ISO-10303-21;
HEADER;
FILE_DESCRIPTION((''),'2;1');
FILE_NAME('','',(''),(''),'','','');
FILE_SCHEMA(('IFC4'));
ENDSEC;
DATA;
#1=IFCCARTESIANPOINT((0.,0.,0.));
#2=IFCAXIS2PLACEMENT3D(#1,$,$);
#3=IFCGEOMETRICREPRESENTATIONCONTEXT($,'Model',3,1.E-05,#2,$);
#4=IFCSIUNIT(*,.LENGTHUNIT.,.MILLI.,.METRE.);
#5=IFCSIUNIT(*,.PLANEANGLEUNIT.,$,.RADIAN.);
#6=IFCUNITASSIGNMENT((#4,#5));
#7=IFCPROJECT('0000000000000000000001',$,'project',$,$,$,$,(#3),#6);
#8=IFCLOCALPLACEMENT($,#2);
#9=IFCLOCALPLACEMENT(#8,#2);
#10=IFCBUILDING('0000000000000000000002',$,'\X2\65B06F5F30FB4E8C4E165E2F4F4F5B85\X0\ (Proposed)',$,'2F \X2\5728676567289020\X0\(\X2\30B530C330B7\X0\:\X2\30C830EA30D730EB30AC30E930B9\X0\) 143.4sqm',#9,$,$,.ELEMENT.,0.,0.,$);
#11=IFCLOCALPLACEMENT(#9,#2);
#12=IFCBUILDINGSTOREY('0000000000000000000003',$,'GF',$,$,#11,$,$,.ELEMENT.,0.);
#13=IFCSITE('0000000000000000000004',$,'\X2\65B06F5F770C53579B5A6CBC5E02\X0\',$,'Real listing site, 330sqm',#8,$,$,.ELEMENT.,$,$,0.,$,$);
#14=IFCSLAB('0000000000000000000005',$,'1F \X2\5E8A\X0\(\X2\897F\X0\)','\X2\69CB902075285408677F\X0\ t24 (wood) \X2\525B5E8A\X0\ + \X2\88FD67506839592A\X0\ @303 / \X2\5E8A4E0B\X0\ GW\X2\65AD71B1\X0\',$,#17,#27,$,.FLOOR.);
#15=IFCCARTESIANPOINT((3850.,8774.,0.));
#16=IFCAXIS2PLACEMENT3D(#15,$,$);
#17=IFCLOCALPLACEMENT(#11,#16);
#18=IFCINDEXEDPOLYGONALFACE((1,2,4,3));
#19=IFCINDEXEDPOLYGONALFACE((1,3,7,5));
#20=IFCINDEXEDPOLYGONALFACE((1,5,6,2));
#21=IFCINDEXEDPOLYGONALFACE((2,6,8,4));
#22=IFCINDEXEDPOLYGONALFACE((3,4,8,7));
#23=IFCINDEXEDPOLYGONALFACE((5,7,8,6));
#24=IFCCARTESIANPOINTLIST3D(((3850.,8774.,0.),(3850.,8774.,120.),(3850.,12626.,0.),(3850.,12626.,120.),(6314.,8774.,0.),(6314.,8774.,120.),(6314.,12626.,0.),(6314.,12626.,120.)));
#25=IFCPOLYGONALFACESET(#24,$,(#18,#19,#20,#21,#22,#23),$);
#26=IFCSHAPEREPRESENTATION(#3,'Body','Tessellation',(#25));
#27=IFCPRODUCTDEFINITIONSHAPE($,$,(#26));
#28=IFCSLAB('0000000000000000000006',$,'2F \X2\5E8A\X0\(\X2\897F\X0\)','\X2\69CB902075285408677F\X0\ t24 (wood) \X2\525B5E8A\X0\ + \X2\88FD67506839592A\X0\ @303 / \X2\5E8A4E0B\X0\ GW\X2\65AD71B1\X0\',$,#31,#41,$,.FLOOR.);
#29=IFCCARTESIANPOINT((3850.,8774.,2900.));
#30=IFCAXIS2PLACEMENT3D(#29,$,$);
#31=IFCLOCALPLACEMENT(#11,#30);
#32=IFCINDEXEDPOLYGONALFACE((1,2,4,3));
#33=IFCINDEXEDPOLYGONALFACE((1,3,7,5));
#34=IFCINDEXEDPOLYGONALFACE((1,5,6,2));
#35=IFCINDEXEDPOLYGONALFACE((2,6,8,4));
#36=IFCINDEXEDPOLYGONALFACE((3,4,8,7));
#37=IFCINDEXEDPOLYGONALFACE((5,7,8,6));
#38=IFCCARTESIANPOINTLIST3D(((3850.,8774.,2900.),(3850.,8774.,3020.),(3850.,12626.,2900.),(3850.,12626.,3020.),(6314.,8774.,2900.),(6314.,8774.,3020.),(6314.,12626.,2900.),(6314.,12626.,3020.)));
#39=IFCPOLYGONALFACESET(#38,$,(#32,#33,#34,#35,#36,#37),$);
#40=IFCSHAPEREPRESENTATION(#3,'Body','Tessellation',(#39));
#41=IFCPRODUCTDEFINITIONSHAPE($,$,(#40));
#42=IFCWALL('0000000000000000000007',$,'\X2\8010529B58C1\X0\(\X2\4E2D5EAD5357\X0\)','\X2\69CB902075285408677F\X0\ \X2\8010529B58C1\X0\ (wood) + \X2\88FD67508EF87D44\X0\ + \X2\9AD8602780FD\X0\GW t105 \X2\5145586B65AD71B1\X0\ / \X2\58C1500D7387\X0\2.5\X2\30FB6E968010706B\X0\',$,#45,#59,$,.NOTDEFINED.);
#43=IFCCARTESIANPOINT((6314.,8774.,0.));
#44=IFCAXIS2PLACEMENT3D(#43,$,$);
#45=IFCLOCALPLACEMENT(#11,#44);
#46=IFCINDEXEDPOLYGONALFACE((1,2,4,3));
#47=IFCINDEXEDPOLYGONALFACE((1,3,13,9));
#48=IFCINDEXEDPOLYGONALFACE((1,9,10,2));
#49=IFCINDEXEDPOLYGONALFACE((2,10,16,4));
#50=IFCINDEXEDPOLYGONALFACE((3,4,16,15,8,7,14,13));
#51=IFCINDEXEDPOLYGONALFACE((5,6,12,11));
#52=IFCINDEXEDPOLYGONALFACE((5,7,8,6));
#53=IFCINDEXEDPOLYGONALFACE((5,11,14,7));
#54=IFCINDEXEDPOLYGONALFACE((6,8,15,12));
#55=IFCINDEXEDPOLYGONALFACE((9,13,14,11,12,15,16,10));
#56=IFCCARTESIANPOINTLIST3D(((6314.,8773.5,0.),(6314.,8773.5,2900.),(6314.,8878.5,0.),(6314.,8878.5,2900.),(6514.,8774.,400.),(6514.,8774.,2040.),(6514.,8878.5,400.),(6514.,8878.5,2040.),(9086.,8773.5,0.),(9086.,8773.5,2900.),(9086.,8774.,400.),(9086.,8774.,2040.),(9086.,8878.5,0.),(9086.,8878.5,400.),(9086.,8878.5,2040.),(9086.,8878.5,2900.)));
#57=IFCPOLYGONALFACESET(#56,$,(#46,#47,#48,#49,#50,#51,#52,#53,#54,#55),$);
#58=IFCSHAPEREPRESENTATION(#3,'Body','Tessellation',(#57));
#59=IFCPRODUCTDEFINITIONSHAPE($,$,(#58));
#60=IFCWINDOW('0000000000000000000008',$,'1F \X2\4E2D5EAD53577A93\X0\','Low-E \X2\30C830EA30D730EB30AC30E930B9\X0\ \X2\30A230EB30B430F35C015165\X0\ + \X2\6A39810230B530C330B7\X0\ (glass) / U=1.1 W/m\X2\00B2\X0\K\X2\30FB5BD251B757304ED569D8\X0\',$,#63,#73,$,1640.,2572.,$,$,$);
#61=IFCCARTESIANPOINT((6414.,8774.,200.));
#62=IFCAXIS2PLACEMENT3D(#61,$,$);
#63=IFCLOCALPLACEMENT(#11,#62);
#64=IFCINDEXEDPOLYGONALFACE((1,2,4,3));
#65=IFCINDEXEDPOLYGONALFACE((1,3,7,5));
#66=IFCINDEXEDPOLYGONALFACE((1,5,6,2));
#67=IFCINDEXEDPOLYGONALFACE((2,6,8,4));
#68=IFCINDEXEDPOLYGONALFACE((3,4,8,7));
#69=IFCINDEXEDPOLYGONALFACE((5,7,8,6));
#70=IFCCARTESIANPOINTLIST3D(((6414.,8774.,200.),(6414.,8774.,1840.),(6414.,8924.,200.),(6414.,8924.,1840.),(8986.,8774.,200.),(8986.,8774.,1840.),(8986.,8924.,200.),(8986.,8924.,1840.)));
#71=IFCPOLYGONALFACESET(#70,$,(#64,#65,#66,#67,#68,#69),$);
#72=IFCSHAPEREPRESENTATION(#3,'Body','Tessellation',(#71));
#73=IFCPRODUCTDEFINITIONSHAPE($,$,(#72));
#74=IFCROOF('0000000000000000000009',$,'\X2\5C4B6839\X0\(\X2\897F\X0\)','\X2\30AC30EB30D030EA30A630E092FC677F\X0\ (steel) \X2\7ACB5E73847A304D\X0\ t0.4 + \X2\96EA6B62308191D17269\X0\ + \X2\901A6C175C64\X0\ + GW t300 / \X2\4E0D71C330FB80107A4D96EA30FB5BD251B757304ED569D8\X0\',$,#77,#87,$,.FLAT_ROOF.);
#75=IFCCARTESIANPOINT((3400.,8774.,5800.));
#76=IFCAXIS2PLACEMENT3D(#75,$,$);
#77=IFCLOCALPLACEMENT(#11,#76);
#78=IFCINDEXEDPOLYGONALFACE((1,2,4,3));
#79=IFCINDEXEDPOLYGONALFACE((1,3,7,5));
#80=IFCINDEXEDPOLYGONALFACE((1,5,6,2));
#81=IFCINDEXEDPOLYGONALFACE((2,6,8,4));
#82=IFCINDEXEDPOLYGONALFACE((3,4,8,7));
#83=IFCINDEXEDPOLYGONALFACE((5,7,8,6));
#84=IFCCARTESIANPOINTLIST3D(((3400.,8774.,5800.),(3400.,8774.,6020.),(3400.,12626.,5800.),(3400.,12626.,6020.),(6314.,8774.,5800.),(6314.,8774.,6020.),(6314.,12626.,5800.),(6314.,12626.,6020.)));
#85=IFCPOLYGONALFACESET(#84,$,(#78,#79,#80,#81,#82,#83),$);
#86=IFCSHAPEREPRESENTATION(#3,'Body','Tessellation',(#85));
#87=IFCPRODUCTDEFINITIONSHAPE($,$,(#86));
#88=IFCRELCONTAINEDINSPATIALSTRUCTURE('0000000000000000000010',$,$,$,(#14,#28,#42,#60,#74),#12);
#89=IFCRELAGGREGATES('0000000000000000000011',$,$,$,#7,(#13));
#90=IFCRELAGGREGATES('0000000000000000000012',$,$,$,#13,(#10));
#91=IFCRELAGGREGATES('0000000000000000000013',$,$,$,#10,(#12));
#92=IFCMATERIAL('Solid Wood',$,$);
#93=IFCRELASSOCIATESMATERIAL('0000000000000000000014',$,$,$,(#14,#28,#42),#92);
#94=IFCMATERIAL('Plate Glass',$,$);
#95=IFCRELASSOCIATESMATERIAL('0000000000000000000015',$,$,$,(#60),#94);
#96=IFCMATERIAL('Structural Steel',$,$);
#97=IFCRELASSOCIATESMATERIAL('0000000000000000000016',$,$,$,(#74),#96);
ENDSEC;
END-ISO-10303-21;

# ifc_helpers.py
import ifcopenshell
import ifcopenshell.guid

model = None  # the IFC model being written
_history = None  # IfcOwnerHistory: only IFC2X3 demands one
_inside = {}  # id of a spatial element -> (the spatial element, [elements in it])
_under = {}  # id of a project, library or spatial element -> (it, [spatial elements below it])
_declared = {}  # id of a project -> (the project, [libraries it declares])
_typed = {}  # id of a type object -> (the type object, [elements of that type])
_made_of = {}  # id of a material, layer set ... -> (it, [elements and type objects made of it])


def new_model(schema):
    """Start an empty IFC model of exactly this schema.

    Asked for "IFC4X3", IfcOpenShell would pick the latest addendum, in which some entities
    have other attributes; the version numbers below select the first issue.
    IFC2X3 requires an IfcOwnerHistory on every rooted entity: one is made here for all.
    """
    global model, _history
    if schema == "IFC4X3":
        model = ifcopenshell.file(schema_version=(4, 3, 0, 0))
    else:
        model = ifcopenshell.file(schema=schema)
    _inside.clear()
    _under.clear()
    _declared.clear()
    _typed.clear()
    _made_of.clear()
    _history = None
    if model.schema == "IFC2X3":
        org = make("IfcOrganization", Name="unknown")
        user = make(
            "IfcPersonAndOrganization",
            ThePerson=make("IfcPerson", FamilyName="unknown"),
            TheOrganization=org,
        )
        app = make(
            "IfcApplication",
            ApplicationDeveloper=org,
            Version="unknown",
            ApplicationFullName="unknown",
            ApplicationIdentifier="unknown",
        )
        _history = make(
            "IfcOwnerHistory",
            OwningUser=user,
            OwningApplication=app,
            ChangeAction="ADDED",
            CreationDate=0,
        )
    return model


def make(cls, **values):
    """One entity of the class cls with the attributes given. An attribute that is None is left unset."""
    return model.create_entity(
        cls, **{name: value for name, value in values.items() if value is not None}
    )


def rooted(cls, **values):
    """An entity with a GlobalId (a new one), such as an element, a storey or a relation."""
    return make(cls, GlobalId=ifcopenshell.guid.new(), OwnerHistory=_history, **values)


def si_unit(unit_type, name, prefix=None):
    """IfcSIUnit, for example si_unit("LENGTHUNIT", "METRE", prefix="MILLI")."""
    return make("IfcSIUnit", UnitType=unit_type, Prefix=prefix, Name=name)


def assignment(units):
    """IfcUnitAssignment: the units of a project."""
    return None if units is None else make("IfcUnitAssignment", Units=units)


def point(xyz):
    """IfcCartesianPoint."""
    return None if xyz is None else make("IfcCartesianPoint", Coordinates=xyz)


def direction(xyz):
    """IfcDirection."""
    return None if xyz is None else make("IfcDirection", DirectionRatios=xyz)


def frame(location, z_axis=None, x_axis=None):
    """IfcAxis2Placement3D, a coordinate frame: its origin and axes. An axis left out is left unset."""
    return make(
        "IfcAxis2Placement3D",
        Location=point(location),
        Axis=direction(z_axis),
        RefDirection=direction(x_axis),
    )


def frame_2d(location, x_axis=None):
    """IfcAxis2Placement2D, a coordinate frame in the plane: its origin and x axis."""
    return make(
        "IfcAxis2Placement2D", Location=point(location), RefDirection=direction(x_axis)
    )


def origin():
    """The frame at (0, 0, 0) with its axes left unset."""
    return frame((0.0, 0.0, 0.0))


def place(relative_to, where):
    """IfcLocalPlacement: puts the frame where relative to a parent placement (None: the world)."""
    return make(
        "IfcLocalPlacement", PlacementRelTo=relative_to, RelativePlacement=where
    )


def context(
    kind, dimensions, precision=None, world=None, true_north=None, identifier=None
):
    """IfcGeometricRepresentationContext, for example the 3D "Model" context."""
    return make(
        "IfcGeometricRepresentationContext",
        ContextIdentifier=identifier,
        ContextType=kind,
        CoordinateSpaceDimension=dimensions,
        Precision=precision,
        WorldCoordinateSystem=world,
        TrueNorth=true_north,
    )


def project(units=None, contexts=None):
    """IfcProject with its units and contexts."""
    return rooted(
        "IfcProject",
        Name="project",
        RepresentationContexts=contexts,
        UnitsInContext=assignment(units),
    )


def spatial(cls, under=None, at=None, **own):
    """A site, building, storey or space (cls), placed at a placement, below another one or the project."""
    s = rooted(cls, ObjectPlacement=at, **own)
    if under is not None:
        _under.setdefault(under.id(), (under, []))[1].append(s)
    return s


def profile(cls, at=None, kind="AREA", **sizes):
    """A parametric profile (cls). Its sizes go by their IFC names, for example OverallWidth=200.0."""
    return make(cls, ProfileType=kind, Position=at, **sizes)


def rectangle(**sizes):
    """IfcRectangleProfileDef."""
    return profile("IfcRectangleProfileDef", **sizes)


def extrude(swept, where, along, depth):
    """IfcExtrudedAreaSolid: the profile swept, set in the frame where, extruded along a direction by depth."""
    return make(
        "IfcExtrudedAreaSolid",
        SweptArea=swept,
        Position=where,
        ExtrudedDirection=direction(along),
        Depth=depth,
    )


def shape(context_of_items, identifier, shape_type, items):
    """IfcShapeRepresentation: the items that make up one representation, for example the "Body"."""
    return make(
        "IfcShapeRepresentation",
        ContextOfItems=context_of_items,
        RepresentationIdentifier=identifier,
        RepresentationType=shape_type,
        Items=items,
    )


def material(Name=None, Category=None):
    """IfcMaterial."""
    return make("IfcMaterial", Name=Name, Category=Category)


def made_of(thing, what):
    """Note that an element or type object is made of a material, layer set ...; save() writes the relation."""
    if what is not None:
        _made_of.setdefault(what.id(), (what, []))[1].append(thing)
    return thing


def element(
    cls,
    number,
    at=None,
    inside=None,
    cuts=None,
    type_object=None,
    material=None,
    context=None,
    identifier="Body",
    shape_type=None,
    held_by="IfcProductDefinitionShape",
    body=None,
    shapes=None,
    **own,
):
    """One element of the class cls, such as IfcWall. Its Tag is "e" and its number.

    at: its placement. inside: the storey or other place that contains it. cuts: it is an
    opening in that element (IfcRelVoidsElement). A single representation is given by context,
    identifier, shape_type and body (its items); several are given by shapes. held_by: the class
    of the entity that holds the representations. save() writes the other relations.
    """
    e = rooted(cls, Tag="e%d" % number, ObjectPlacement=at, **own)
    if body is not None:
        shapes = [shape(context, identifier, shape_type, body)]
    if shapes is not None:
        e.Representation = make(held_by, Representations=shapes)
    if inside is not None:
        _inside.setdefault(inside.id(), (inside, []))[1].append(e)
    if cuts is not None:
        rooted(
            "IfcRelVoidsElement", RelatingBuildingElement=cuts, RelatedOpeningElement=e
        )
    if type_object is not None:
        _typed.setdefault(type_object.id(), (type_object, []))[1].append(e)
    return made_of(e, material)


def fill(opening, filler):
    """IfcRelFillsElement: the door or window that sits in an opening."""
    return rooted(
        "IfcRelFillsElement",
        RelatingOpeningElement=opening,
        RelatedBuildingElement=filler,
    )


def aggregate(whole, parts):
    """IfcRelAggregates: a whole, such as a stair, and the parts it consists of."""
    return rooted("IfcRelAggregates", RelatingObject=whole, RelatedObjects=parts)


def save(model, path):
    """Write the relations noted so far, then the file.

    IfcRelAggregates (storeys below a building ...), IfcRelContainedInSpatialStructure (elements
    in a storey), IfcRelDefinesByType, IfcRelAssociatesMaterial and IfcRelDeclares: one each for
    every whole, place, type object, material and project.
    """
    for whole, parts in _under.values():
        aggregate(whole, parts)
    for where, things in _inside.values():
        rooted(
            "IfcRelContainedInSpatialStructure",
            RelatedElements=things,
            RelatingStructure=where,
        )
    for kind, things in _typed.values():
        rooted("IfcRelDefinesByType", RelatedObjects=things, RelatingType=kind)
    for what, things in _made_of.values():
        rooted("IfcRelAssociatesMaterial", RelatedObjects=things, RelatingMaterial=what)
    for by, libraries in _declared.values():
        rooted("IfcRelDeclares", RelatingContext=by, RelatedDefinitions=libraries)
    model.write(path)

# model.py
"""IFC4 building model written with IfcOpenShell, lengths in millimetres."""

from ifc_helpers import new_model, si_unit, frame, frame_2d, origin, place, context, project, spatial, rectangle, extrude, material, element, fill, save


model = new_model("IFC4")

# Units and contexts
model_context = context("Model", 3, precision=1e-05, world=origin())
ifc_project = project(units=[si_unit("LENGTHUNIT", "METRE", prefix="MILLI"), si_unit("PLANEANGLEUNIT", "RADIAN")], contexts=[model_context])

# Site, building, storey
site_placement = place(None, origin())
site = spatial("IfcSite", under=ifc_project, at=site_placement, Name="新潟県南魚沼市", ObjectType="Real listing site, 330sqm", CompositionType="ELEMENT", RefElevation=0.0)
building_placement = place(site_placement, origin())
building = spatial("IfcBuilding", under=site, at=building_placement, Name="新潟・二世帯住宅 (Proposed)", ObjectType="2F 在来木造(サッシ:トリプルガラス) 143.4sqm", CompositionType="ELEMENT", ElevationOfRefHeight=0.0, ElevationOfTerrain=0.0)
storey_placement = place(building_placement, origin())
storey = spatial("IfcBuildingStorey", under=building, at=storey_placement, Name="GF", CompositionType="ELEMENT", Elevation=0.0)

# Shared definitions
ifc_material_1 = material(Name="Solid Wood")

# Slabs
slab_1_placement = place(storey_placement, frame((3850.0, 8774.0, 0.0)))
element("IfcSlab", 1, at=slab_1_placement, inside=storey, material=ifc_material_1, Name="1F 床(西)", Description="構造用合板 t24 (wood) 剛床 + 製材根太 @303 / 床下 GW断熱", PredefinedType="FLOOR", context=model_context, shape_type="SweptSolid", body=[
    extrude(rectangle(XDim=2464.0, YDim=3852.0, at=frame_2d((1232.0, 1926.0))), frame((3850.0, 8774.0, 0.0)), (0.0, 0.0, 1.0), 120.0),
])
slab_2_placement = place(storey_placement, frame((3850.0, 8774.0, 2900.0)))
element("IfcSlab", 2, at=slab_2_placement, inside=storey, material=ifc_material_1, Name="2F 床(西)", Description="構造用合板 t24 (wood) 剛床 + 製材根太 @303 / 床下 GW断熱", PredefinedType="FLOOR", context=model_context, shape_type="SweptSolid", body=[
    extrude(rectangle(XDim=2464.0, YDim=3852.0, at=frame_2d((1232.0, 1926.0))), frame((3850.0, 8774.0, 2900.0)), (0.0, 0.0, 1.0), 120.0),
])

# Wall, opening, window
wall_1_placement = place(storey_placement, frame((6314.0, 8774.0, 0.0)))
wall_1 = element("IfcWall", 3, at=wall_1_placement, inside=storey, material=ifc_material_1, Name="耐力壁(中庭南)", Description="構造用合板 耐力壁 (wood) + 製材軸組 + 高性能GW t105 充填断熱 / 壁倍率2.5・準耐火", PredefinedType="NOTDEFINED", context=model_context, shape_type="SweptSolid", body=[
    extrude(rectangle(XDim=2772.0, YDim=105.0, at=frame_2d((1386.0, 52.0))), frame((6314.0, 8774.0, 0.0)), (0.0, 0.0, 1.0), 2900.0),
])
opening_placement = place(storey_placement, frame((6414.0, 8774.0, 200.0)))
opening = element("IfcOpeningElement", 4, at=opening_placement, cuts=wall_1, PredefinedType="NOTDEFINED", context=model_context, shape_type="SweptSolid", body=[
    extrude(rectangle(XDim=2572.0, YDim=150.0, at=frame_2d((1286.0, 75.0))), frame((6414.0, 8774.0, 200.0)), (0.0, 0.0, 1.0), 1640.0),
])
ifc_material_2 = material(Name="Plate Glass")
window_placement = place(storey_placement, frame((6414.0, 8774.0, 200.0)))
window = element("IfcWindow", 5, at=window_placement, inside=storey, material=ifc_material_2, Name="1F 中庭南窓", Description="Low-E トリプルガラス アルゴン封入 + 樹脂サッシ (glass) / U=1.1 W/m²K・寒冷地仕様", OverallHeight=1640.0, OverallWidth=2572.0, context=model_context, shape_type="SweptSolid", body=[
    extrude(rectangle(XDim=2572.0, YDim=150.0, at=frame_2d((1286.0, 75.0))), frame((6414.0, 8774.0, 200.0)), (0.0, 0.0, 1.0), 1640.0),
])
fill(opening, window)

# Roof
ifc_material_3 = material(Name="Structural Steel")
for number, where, name in (
    (6, (3400.0, 8774.0, 5800.0), "屋根(西)"),
):
    element("IfcRoof", number, at=place(storey_placement, frame(where)), inside=storey, material=ifc_material_3, Name=name, Description="ガルバリウム鋼板 (steel) 立平葺き t0.4 + 雪止め金物 + 通気層 + GW t300 / 不燃・耐積雪・寒冷地仕様", PredefinedType="FLAT_ROOF", context=model_context, shape_type="SweptSolid", body=[
        extrude(rectangle(XDim=2914.0, YDim=3852.0, at=frame_2d((1457.0, 1926.0))), frame((3400.0, 8774.0, 5800.0)), (0.0, 0.0, 1.0), 220.0),
    ])

save(model, "model.ifc")
